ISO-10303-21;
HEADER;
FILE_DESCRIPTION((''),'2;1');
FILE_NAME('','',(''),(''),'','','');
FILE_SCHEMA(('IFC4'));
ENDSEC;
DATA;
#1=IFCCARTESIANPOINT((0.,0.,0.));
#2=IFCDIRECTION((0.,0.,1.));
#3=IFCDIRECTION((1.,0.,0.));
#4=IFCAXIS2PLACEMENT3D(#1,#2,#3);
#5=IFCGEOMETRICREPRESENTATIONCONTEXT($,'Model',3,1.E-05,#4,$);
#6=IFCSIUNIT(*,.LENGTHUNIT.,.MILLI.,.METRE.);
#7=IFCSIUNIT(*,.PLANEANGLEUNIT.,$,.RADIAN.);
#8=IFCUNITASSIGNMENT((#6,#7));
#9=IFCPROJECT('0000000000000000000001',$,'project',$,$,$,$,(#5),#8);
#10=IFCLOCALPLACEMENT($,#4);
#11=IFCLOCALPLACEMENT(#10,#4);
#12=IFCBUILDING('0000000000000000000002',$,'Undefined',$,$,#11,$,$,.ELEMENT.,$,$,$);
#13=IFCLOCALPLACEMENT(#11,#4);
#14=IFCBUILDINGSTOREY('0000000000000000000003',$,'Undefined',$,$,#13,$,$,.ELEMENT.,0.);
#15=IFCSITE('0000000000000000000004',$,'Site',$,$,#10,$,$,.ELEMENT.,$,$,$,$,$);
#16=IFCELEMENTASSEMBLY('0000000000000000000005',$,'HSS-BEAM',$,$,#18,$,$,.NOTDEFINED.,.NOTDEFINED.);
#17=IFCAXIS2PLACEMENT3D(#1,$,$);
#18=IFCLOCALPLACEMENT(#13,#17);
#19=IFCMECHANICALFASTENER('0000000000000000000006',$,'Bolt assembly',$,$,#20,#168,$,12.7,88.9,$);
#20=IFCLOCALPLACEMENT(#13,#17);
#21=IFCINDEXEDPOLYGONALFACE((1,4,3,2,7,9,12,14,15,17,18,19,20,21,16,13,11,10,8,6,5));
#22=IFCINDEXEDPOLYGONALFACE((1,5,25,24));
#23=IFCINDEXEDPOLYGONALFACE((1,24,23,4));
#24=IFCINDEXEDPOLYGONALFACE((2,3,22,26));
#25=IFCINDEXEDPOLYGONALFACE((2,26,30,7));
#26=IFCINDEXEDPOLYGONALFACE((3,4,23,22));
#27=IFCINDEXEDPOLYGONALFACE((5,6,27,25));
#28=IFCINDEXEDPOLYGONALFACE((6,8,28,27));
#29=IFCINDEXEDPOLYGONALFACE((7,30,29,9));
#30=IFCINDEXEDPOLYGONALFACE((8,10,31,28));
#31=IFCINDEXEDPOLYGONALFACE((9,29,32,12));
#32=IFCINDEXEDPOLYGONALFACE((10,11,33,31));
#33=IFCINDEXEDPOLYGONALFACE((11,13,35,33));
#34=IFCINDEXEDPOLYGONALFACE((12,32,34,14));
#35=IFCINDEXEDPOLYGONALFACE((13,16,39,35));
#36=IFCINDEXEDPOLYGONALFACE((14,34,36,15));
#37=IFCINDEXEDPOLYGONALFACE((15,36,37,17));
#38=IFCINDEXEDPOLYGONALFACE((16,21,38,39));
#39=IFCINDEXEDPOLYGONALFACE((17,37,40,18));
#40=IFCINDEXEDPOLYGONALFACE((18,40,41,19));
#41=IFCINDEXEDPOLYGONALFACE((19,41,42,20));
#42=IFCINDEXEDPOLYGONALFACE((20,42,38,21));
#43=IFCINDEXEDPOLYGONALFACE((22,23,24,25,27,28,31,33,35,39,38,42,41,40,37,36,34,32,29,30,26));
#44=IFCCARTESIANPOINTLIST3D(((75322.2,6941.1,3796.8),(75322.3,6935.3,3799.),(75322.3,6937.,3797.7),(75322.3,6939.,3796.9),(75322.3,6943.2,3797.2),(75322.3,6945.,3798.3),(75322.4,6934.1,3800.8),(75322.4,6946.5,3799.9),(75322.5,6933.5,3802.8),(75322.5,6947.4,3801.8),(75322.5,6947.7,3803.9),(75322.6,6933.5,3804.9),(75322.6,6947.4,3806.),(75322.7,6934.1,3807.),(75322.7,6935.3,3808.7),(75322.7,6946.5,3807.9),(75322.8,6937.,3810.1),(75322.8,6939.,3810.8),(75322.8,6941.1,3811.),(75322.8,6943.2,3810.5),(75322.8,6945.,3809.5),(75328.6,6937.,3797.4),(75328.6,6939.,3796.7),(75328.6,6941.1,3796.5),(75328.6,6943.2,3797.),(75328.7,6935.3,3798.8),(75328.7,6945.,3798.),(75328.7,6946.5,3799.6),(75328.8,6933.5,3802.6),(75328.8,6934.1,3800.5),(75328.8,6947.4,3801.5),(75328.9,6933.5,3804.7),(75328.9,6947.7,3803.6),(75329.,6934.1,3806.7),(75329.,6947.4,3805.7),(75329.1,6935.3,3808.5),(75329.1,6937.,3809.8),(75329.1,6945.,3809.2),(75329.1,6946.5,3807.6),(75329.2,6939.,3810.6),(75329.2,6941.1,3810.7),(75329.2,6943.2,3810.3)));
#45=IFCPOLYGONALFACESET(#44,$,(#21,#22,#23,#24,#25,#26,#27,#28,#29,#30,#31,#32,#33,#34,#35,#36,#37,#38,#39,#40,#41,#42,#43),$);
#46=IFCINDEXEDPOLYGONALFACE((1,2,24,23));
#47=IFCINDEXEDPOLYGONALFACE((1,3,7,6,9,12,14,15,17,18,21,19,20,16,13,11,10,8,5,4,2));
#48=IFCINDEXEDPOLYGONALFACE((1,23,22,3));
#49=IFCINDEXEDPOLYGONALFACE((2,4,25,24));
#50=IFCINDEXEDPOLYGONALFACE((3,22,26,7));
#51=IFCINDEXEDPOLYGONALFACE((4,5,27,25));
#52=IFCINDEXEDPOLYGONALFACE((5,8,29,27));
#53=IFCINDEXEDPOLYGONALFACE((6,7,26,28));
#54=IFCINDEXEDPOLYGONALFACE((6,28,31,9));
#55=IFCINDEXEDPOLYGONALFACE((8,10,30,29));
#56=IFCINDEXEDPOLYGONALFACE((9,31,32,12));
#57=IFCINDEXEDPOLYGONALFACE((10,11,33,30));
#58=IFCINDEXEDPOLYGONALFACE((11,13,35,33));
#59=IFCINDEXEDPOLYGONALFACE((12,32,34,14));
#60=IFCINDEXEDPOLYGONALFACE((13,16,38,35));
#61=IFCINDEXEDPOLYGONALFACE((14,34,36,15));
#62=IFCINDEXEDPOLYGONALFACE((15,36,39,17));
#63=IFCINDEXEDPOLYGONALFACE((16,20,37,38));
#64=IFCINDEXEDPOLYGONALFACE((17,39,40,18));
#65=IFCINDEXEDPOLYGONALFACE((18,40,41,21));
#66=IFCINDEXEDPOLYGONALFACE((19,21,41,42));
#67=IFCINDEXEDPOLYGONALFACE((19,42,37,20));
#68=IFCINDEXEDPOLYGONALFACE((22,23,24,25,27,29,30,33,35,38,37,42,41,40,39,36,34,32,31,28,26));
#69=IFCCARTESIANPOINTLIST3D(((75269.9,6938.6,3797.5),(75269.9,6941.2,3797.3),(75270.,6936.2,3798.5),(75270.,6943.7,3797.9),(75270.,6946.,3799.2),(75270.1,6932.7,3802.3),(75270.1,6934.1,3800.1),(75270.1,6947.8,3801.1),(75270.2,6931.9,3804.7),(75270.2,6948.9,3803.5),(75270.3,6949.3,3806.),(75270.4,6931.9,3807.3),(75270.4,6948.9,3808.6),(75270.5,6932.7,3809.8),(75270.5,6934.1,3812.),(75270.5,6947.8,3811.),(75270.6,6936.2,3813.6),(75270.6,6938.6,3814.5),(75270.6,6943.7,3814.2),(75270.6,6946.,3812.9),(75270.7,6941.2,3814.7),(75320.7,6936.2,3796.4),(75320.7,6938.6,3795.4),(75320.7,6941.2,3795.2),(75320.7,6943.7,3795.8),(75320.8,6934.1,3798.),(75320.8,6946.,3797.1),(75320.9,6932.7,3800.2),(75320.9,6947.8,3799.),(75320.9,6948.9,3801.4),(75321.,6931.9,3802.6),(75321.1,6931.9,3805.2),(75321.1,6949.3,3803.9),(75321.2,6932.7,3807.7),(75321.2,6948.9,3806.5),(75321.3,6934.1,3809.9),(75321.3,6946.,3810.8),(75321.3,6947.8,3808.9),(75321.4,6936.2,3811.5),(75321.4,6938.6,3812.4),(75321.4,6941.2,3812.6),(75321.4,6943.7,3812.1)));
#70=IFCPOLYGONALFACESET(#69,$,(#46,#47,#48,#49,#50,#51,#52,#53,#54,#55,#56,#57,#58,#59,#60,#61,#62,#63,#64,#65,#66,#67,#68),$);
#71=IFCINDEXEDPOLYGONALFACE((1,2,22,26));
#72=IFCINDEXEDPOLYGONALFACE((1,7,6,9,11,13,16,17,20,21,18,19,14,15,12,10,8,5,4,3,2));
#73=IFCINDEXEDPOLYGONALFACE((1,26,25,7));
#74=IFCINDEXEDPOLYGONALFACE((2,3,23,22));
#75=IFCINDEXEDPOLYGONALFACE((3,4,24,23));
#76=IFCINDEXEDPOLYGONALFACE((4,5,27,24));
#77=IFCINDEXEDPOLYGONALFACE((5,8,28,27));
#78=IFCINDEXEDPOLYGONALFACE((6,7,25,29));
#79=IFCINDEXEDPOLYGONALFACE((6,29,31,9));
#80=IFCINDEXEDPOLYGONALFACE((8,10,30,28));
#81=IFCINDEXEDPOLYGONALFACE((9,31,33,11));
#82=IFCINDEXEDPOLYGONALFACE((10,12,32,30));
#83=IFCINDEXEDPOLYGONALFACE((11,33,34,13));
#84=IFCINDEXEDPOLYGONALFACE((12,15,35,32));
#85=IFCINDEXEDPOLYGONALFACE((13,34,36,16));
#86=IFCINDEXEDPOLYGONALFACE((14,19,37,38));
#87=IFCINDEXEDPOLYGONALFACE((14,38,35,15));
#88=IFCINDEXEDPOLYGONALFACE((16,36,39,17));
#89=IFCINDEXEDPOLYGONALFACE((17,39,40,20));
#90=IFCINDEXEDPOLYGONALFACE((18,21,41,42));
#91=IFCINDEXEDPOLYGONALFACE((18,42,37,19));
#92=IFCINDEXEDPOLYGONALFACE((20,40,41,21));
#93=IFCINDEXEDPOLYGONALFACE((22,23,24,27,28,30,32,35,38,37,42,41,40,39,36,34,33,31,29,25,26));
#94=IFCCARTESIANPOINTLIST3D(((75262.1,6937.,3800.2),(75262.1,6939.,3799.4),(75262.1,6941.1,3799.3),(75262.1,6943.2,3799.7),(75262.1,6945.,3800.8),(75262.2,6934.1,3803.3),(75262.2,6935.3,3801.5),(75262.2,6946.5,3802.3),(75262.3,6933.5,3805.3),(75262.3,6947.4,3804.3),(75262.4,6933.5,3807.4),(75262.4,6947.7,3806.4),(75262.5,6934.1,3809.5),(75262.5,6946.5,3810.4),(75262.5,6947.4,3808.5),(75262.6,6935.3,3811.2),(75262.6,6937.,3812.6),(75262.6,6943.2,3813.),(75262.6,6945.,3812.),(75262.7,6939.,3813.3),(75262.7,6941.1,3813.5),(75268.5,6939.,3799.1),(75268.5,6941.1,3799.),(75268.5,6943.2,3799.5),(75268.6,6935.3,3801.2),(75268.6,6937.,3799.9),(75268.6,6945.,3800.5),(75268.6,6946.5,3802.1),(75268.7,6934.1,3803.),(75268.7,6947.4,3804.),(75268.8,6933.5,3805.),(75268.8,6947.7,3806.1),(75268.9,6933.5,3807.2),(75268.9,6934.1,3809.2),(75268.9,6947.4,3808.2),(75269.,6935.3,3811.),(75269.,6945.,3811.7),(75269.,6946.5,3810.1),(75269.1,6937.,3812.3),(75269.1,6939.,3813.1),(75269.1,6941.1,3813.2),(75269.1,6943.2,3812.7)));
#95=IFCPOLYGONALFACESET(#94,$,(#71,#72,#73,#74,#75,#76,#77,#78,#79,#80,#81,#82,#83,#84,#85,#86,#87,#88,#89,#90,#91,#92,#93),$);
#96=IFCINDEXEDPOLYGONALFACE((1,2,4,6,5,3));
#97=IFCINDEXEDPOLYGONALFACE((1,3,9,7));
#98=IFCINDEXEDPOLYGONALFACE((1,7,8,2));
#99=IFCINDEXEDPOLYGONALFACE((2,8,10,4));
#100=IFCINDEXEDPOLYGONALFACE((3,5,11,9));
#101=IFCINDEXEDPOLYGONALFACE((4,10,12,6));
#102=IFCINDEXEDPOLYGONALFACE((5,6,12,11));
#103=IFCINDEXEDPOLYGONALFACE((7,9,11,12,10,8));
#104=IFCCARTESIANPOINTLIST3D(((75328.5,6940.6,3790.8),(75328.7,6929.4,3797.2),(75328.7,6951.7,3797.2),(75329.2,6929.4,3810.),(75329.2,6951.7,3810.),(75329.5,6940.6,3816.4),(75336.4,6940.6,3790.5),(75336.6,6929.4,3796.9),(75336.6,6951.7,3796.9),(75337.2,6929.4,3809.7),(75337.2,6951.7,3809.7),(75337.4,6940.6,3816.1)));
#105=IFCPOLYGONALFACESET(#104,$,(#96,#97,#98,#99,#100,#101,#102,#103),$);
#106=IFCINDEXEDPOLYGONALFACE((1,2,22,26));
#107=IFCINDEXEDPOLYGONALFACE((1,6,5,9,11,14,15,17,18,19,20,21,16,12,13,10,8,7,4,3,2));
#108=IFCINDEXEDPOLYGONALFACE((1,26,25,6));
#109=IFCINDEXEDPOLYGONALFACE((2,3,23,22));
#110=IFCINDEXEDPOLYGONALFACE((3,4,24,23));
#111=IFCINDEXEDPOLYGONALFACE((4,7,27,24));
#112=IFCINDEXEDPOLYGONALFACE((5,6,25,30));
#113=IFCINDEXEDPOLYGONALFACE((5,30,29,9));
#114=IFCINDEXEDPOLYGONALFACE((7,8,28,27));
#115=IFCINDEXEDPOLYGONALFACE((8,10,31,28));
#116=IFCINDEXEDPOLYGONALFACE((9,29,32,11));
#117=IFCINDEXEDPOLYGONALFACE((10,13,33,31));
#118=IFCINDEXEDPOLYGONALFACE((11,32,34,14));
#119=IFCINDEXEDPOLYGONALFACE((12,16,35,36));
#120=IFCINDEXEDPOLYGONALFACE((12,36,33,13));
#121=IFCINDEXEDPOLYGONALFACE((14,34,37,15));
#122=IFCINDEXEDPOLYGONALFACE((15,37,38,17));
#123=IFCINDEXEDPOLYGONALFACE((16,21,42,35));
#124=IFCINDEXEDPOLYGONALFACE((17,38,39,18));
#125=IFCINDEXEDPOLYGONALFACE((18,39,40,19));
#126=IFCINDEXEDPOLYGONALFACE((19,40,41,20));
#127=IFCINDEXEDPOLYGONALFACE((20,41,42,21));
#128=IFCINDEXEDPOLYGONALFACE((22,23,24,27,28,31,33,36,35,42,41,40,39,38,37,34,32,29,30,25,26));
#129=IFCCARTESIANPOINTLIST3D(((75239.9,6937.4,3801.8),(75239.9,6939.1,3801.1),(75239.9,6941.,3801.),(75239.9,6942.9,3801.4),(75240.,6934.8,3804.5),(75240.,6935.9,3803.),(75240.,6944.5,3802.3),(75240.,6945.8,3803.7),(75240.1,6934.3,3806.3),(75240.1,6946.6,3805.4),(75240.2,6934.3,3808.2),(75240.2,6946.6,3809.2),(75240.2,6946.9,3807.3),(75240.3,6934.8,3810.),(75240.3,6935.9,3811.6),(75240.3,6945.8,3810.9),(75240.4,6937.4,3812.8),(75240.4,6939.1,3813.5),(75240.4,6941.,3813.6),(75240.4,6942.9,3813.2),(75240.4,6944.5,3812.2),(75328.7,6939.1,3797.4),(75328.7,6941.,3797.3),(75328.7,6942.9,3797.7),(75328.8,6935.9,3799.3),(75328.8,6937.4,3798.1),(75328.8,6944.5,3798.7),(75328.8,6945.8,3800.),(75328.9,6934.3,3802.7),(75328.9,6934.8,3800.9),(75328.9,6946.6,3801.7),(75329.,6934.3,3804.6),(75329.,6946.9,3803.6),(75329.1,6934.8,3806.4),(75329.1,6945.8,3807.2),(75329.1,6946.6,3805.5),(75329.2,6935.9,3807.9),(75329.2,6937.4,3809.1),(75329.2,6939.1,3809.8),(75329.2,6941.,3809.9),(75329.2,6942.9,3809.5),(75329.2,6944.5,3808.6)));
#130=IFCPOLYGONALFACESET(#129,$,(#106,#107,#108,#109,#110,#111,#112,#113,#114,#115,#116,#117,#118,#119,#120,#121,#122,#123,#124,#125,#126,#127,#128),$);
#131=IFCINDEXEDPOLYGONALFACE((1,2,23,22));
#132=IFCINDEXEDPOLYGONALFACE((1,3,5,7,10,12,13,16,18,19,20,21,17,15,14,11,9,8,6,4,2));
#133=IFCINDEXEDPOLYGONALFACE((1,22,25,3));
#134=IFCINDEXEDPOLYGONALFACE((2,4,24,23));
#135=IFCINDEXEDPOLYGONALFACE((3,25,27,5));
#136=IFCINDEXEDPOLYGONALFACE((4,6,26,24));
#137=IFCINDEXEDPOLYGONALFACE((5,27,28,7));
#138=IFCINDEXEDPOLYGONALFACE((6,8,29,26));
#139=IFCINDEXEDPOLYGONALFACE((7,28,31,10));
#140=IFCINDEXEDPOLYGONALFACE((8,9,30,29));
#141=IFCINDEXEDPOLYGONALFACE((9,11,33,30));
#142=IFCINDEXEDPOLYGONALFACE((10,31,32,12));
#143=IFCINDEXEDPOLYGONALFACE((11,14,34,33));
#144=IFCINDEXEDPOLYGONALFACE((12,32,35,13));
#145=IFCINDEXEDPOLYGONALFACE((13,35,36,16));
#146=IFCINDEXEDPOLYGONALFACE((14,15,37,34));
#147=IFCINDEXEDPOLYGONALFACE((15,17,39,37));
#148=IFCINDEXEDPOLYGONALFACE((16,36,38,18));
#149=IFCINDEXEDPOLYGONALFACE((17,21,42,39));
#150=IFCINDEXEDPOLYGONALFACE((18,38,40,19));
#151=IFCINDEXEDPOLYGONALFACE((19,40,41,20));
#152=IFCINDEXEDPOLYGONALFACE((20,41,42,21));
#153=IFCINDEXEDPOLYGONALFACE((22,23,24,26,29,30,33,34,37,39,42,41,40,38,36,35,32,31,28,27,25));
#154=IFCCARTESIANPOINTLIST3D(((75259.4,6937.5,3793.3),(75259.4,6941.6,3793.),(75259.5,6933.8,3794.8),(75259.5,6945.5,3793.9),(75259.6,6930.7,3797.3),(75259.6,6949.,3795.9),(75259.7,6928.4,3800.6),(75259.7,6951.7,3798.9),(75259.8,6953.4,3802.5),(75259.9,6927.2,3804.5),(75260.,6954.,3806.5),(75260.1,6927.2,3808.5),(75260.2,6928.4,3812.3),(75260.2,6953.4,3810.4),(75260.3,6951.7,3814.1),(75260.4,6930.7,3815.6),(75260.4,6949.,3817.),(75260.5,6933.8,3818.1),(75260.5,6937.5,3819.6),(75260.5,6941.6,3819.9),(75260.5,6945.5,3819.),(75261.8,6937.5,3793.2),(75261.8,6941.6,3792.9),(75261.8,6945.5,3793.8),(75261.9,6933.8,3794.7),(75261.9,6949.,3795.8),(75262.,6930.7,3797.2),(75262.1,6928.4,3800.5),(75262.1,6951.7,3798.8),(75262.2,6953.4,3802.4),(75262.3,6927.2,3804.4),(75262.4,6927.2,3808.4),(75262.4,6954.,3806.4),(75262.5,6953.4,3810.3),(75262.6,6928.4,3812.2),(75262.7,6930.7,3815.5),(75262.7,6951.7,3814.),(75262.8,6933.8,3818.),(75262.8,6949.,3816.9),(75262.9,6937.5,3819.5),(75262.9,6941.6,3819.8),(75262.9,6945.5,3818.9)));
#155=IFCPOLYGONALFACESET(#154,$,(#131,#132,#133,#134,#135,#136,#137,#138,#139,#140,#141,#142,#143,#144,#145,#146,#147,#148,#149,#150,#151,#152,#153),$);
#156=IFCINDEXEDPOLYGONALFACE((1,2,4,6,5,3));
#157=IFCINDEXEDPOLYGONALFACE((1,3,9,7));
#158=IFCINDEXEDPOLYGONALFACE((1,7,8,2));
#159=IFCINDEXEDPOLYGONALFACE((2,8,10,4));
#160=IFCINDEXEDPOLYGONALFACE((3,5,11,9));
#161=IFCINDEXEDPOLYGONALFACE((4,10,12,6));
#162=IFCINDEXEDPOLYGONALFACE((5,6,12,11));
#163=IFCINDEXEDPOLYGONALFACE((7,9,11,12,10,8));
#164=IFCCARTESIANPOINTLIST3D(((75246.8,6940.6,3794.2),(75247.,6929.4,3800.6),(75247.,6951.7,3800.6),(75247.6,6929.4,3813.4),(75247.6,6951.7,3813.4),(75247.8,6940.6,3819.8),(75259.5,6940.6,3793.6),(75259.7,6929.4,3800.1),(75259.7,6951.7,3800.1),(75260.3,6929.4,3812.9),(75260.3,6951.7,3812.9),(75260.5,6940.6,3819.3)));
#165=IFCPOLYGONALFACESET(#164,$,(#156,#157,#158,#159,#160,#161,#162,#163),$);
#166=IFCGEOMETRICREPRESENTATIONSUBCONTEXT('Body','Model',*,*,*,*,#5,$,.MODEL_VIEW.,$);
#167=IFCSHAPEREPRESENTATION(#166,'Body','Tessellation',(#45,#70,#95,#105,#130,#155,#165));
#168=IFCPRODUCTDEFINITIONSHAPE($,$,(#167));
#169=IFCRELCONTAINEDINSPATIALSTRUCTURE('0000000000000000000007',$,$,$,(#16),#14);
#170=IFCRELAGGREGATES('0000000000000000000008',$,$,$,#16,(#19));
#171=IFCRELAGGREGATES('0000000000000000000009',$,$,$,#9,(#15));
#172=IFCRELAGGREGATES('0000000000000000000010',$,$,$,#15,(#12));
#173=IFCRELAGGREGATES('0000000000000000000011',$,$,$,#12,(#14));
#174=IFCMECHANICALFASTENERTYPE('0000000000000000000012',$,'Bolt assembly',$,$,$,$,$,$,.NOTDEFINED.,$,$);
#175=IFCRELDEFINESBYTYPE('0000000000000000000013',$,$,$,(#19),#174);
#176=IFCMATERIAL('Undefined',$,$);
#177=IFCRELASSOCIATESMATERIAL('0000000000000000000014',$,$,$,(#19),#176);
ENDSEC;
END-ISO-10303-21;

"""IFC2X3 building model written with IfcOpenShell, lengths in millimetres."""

from ifc_helpers import new_model, si_unit, frame, origin_with_axes, origin_2d_with_axis, place, context, subcontext, project, spatial, polyline, circle, outline, extrude, source, transform, mapped, material, type_object, element, aggregate, save


model = new_model("IFC2X3")

# Units and contexts
model_context = context("Model", 3, precision=1e-05, world=origin_with_axes())
body_context = subcontext(model_context, "Body", "Model", "MODEL_VIEW")
ifc_project = project(units=[si_unit("LENGTHUNIT", "METRE", prefix="MILLI"), si_unit("PLANEANGLEUNIT", "RADIAN")], contexts=[model_context])

# Site, building, storey
site_placement = place(None, origin_with_axes())
site = spatial("IfcSite", under=ifc_project, at=site_placement, Name="Site", CompositionType="ELEMENT")
building_placement = place(site_placement, origin_with_axes())
building = spatial("IfcBuilding", under=site, at=building_placement, Name="Undefined", CompositionType="ELEMENT")
storey_placement = place(building_placement, origin_with_axes())
storey = spatial("IfcBuildingStorey", under=building, at=storey_placement, Name="Undefined", CompositionType="ELEMENT", Elevation=0.0)

# Element assembly
assembly_1_placement = place(storey_placement, origin_with_axes())
assembly_1 = element("IfcElementAssembly", 1, at=assembly_1_placement, inside=storey, Name="HSS-BEAM", AssemblyPlace="NOTDEFINED", PredefinedType="NOTDEFINED")

# Shared definitions
ifc_material_1 = material(Name="Undefined")
mechanical_fastener_type = type_object("IfcMechanicalFastenerType", Name="Bolt assembly")

# Shared definitions
shared_shape_1 = source(origin_with_axes(), body_context, "Body", "SweptSolid", [
    extrude(circle(Radius=7.1, at=origin_2d_with_axis()), frame((0.0, -33.2, 0.0), z_axis=(0.0, 1.0, 0.0), x_axis=(1.0, 0.0, 0.0)), (0.0, 0.0, 1.0), 6.3),
    extrude(circle(Radius=8.7, at=origin_2d_with_axis()), frame((0.0, -25.4, 0.0), z_axis=(0.0, 1.0, 0.0), x_axis=(1.0, 0.0, 0.0)), (0.0, 0.0, 1.0), 50.8),
    extrude(circle(Radius=7.1, at=origin_2d_with_axis()), frame((0.0, 26.9, 0.0), z_axis=(0.0, 1.0, 0.0), x_axis=(1.0, 0.0, 0.0)), (0.0, 0.0, 1.0), 6.5),
    extrude(outline(polyline([(11.1, -6.4), (11.1, 6.4), (0.0, 12.8), (-11.1, 6.4), (-11.1, -6.4), (0.0, -12.8), (11.1, -6.4)])), frame((0.0, -41.3, 0.0), z_axis=(0.0, 1.0, 0.0), x_axis=(1.0, 0.0, 0.0)), (0.0, 0.0, 1.0), 7.9),
    extrude(circle(Radius=6.3, at=origin_2d_with_axis()), frame((0.0, -33.3, 0.0), z_axis=(0.0, 1.0, 0.0), x_axis=(1.0, 0.0, 0.0)), (0.0, 0.0, 1.0), 88.9),
    extrude(circle(Radius=13.5, at=origin_2d_with_axis()), frame((0.0, 33.3, 0.0), z_axis=(0.0, 1.0, 0.0), x_axis=(1.0, 0.0, 0.0)), (0.0, 0.0, 1.0), 2.4),
    extrude(outline(polyline([(11.1, -6.4), (11.1, 6.4), (0.0, 12.8), (-11.1, 6.4), (-11.1, -6.4), (0.0, -12.8), (11.1, -6.4)])), frame((0.0, 35.7, 0.0), z_axis=(0.0, 1.0, 0.0), x_axis=(1.0, 0.0, 0.0)), (0.0, 0.0, 1.0), 12.7),
])

# Mechanical fastener
mechanical_fastener_1_placement = place(assembly_1_placement, frame((75295.7, 6940.6, 3805.0), z_axis=(0.041337, 0.0, 0.999145), x_axis=(0.0, 1.0, 0.0)))
mechanical_fastener_1 = element("IfcMechanicalFastener", 2, at=mechanical_fastener_1_placement, type_object=mechanical_fastener_type, material=ifc_material_1, Name="Bolt assembly", NominalDiameter=12.7, NominalLength=88.9, context=body_context, shape_type="MappedRepresentation", body=[
    mapped(shared_shape_1, transform((0.0, 0.0, 0.0))),
])
aggregate(assembly_1, [mechanical_fastener_1])

save(model, "model.ifc")
